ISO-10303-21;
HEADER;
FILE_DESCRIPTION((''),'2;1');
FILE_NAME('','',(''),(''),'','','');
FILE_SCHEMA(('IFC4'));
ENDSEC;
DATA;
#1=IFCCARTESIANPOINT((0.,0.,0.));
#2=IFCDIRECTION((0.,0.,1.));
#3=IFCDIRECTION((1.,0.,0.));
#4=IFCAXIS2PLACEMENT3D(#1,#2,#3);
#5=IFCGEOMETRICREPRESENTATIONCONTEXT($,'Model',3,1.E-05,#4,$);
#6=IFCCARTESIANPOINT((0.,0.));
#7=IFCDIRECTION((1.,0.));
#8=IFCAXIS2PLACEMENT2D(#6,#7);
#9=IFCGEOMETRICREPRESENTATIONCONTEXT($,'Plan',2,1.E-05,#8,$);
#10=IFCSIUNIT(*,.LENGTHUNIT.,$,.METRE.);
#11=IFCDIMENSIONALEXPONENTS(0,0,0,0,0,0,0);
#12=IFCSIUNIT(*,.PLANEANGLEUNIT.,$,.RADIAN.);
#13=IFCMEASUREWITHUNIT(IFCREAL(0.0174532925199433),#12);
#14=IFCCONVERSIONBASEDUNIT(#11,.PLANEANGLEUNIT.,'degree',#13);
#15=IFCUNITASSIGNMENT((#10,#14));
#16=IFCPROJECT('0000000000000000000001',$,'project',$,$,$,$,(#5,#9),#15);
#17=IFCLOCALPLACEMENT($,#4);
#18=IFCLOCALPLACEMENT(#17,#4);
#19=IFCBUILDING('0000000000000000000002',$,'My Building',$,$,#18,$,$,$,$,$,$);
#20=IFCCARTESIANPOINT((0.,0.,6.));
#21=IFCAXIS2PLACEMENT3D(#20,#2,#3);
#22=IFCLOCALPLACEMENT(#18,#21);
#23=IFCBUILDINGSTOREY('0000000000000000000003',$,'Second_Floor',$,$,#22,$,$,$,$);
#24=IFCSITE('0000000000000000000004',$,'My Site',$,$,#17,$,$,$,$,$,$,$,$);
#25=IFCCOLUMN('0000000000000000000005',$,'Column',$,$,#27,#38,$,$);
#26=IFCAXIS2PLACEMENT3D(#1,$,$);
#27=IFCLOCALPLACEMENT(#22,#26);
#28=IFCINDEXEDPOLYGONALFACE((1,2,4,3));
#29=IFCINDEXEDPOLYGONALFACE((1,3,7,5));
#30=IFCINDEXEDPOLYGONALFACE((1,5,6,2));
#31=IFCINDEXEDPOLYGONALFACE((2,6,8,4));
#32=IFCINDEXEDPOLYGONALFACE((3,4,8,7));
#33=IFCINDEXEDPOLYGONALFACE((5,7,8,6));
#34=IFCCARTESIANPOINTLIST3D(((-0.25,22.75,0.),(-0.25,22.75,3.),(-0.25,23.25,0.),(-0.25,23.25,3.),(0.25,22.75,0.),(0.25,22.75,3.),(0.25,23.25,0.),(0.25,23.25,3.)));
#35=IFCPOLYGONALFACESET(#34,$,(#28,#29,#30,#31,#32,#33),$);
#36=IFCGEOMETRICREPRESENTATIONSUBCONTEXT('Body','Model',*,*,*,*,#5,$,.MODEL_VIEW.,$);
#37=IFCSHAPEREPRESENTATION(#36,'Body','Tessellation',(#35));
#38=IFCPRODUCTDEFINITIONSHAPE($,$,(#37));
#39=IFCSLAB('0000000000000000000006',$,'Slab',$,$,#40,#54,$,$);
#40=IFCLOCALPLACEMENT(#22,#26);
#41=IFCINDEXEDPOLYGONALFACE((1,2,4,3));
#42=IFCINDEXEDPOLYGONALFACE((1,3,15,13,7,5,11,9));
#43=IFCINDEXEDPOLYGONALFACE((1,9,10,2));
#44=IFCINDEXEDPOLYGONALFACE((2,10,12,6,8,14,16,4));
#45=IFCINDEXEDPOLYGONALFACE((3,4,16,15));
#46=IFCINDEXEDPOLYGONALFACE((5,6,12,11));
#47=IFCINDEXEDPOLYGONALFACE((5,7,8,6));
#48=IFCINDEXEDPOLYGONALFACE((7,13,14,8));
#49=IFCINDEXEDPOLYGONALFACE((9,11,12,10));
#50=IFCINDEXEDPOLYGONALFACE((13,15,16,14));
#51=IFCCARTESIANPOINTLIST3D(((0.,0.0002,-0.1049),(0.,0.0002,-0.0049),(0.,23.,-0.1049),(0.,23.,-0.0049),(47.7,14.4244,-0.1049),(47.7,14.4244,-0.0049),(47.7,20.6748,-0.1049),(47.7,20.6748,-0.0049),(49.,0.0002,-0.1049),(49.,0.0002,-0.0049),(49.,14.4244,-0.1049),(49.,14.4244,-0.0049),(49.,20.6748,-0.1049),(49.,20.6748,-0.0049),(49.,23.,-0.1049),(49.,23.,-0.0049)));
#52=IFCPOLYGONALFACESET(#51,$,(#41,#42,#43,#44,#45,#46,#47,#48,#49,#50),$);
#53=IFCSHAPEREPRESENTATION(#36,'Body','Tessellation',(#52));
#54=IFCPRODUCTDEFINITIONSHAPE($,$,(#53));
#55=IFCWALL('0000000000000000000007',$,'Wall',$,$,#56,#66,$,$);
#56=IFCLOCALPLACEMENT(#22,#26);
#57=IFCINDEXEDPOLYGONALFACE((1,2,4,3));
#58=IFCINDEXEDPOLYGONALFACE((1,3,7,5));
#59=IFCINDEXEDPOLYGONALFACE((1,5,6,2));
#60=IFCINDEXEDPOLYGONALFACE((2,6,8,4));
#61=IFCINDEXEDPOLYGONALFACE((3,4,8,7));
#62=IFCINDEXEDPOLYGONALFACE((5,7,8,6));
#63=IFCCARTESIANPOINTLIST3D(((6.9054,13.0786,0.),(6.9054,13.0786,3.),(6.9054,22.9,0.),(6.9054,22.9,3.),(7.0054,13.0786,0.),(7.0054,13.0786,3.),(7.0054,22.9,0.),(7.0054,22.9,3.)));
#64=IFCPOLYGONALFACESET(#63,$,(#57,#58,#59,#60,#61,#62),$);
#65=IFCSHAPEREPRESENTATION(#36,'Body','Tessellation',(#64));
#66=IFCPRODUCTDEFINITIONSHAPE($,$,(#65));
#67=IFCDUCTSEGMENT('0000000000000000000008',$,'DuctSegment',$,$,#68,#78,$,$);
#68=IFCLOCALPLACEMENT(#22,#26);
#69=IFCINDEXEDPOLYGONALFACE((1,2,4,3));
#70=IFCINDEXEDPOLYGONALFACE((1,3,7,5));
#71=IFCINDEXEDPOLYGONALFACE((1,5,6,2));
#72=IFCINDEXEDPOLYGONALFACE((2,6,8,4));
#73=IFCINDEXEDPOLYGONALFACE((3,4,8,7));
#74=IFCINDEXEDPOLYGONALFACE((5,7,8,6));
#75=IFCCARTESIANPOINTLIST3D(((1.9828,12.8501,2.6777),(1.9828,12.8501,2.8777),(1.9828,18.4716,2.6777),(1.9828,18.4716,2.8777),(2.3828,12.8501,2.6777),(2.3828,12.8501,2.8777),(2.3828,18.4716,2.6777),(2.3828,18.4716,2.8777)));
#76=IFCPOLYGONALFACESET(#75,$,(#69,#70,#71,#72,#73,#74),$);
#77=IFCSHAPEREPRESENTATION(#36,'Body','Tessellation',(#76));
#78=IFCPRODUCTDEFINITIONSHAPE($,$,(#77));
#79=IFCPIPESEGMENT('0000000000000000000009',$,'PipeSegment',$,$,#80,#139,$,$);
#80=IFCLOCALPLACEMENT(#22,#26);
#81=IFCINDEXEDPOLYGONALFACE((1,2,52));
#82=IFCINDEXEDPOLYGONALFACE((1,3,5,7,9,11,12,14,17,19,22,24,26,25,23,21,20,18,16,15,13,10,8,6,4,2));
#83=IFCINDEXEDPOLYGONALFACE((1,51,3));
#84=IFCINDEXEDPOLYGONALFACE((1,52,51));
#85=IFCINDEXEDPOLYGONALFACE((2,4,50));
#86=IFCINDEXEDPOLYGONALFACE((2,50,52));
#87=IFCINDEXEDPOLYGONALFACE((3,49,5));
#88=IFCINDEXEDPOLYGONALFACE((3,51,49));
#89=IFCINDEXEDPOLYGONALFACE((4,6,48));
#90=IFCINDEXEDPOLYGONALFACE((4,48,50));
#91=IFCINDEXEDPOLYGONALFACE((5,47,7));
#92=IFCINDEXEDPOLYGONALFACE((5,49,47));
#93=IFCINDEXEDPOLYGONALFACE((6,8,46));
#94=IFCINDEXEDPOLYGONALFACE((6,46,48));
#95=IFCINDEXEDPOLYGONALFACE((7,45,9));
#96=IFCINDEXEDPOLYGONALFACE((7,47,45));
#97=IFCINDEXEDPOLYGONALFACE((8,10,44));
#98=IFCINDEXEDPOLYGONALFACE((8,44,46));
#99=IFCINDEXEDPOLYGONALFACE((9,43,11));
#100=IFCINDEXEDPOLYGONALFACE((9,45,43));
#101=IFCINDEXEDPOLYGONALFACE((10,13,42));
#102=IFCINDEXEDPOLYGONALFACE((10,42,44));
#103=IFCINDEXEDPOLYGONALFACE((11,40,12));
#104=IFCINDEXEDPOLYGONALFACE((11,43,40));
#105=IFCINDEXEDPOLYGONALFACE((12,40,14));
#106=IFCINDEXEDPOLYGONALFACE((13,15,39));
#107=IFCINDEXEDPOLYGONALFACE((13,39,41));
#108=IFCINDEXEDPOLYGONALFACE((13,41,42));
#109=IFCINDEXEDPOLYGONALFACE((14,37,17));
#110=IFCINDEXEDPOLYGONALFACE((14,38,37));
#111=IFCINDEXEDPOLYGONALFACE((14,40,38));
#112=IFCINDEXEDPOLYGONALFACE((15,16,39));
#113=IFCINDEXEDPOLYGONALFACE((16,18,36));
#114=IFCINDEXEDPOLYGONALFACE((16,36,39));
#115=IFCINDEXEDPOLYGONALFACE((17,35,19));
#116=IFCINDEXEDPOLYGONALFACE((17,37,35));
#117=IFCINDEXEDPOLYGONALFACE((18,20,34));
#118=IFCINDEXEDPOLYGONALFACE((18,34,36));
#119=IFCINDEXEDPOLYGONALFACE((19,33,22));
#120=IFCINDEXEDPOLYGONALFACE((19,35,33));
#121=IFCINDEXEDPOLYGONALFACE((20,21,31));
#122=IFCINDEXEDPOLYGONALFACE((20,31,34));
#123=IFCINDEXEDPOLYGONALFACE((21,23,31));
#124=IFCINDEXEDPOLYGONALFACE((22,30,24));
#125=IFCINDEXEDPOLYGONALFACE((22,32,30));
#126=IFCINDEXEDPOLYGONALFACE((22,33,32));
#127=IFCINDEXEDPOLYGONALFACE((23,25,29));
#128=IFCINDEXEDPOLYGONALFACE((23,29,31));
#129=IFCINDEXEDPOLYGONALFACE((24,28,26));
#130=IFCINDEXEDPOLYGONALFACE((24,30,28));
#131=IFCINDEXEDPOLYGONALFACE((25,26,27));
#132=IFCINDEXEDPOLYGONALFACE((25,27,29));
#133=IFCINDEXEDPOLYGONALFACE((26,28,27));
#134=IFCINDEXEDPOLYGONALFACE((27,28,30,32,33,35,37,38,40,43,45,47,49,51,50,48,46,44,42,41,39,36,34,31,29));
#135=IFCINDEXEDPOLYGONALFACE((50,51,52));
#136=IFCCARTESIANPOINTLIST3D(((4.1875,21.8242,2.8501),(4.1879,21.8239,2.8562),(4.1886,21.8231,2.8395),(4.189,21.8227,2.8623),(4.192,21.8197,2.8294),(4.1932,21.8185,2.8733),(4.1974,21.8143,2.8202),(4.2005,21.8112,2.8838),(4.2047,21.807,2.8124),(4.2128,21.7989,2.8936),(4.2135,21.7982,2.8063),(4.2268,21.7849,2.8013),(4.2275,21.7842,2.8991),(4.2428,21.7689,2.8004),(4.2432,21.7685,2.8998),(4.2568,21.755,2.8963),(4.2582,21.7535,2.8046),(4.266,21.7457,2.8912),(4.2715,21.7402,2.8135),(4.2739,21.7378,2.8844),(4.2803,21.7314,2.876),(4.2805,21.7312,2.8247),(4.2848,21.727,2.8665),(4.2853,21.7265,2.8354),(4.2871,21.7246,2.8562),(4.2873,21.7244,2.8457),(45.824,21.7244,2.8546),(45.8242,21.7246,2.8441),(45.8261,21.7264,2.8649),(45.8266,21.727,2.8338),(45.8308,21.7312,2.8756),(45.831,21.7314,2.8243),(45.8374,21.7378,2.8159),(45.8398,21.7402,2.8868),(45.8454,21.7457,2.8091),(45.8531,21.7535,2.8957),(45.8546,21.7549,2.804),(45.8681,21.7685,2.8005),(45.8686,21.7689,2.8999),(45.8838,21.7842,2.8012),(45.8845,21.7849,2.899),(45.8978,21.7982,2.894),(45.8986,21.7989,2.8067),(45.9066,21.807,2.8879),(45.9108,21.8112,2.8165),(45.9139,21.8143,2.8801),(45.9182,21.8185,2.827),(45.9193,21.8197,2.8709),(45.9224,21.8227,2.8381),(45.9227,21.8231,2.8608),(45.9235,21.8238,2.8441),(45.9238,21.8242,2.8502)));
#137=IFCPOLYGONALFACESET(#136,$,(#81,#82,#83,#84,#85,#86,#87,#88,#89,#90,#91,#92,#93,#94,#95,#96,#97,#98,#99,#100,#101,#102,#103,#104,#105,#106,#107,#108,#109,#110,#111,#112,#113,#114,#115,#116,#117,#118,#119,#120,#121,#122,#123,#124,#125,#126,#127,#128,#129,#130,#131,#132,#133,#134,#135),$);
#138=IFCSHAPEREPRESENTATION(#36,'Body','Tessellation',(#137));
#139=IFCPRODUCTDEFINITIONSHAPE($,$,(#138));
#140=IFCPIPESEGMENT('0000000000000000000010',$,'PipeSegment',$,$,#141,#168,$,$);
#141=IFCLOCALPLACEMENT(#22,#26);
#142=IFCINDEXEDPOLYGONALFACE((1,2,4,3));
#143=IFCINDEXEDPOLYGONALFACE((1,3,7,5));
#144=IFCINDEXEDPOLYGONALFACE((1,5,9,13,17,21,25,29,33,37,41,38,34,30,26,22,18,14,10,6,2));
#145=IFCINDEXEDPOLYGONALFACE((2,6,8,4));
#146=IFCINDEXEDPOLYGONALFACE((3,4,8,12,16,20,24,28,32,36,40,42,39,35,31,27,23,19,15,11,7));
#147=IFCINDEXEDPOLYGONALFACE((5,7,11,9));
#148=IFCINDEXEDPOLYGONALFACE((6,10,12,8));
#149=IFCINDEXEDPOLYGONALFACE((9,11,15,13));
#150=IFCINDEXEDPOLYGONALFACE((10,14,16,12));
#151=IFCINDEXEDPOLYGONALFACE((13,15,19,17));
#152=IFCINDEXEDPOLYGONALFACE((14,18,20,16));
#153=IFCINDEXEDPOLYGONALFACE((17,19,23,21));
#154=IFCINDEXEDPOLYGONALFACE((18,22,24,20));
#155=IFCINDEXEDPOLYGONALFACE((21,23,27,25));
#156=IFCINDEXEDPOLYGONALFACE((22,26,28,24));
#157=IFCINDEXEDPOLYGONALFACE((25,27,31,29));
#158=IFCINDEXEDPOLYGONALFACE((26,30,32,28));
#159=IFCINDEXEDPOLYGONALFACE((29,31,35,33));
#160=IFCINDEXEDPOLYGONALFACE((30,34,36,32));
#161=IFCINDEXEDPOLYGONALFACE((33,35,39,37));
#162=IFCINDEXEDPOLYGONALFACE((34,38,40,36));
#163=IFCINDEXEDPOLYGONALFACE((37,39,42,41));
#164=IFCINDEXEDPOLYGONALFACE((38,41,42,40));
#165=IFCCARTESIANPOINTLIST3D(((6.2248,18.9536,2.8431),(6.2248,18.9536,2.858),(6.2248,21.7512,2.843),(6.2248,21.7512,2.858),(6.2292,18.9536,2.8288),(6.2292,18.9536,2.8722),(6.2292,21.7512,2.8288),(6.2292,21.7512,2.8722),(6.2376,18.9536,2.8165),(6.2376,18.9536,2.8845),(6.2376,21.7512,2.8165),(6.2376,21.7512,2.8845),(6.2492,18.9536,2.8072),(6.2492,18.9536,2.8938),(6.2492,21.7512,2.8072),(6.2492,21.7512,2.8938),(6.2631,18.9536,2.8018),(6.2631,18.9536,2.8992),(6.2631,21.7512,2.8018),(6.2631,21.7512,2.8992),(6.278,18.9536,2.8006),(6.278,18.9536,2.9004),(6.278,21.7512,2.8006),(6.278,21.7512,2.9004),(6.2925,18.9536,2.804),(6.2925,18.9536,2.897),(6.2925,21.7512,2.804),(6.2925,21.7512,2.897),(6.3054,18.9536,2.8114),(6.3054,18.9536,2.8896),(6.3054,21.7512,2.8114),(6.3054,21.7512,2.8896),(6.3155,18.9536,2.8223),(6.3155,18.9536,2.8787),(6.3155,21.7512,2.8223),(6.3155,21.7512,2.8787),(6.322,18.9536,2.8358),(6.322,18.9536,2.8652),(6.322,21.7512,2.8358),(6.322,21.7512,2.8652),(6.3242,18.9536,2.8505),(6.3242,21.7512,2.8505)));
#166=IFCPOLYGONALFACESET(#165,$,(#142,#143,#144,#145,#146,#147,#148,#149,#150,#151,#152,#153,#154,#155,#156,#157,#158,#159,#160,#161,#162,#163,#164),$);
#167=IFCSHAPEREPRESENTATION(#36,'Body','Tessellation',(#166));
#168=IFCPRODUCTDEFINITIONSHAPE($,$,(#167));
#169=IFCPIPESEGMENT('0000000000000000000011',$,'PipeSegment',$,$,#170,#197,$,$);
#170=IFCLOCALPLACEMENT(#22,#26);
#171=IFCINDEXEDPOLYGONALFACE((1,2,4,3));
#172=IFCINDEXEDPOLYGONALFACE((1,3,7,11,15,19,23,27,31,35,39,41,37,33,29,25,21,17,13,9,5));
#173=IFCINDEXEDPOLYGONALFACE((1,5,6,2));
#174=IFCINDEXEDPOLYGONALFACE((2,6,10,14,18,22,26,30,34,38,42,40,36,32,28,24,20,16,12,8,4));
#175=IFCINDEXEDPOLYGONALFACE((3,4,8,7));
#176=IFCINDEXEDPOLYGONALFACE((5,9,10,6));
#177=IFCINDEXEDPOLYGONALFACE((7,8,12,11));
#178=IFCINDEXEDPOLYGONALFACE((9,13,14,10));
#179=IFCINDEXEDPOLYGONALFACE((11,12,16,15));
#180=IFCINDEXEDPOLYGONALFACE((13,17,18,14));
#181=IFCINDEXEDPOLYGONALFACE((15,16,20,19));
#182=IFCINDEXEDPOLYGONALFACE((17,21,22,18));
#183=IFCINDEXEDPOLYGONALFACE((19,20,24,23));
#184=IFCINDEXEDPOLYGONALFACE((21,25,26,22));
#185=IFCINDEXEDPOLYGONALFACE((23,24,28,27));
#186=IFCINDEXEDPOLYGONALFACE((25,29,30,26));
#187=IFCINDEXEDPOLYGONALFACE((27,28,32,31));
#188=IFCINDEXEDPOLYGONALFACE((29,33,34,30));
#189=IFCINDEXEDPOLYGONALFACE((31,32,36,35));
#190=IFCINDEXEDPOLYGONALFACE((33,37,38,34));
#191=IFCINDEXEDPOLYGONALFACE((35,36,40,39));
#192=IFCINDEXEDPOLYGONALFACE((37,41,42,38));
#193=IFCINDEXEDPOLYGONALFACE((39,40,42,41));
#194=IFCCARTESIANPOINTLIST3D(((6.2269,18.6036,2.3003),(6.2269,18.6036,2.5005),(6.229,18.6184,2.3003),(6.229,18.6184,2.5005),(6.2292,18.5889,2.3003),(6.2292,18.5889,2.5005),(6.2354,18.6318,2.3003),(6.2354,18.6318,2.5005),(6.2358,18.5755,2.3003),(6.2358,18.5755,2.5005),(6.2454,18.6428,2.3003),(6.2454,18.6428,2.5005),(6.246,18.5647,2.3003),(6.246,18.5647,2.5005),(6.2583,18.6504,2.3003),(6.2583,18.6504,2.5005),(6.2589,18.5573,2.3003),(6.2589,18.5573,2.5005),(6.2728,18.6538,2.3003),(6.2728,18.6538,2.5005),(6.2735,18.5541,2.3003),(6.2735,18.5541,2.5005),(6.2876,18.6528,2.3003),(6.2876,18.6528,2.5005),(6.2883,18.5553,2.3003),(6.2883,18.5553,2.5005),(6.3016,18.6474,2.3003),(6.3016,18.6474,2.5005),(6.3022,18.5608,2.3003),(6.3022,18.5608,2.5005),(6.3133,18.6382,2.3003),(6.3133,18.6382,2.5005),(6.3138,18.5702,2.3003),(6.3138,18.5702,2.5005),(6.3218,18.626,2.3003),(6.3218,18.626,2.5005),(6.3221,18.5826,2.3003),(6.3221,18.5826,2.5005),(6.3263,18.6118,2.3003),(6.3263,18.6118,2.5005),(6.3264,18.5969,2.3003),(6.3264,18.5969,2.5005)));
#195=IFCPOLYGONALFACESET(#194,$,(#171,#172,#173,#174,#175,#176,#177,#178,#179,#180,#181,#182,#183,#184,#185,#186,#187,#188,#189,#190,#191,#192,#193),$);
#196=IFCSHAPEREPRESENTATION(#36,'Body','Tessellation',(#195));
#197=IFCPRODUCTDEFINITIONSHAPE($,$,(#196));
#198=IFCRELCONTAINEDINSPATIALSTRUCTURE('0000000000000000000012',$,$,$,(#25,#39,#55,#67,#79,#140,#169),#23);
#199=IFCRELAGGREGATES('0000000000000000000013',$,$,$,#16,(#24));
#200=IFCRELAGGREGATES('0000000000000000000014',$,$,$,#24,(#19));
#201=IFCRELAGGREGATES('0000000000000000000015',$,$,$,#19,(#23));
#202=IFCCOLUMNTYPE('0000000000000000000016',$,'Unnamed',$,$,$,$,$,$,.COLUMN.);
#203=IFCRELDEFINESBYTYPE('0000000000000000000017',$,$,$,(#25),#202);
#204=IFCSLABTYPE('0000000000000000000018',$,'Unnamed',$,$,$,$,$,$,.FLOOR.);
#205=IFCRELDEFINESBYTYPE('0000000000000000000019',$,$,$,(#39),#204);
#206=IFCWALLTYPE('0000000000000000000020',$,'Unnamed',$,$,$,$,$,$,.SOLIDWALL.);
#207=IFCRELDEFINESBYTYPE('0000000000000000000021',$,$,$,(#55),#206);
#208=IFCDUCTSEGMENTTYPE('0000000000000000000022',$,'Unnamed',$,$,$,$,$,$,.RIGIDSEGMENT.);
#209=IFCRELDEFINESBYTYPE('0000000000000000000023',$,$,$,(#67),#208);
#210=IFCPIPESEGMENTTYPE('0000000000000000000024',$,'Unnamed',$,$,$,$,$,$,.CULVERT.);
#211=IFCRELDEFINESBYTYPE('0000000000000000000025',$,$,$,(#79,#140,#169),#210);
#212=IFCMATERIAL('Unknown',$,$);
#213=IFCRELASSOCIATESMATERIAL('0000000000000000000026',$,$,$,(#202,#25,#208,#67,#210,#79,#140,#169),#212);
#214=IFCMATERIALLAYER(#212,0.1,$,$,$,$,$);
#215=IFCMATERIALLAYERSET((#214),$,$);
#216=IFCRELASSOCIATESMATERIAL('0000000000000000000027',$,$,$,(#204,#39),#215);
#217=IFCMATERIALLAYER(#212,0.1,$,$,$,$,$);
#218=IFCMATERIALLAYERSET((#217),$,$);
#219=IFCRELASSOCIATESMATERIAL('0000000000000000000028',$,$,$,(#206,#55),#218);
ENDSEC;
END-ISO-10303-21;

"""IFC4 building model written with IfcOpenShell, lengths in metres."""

from ifc_helpers import new_model, entity, si_unit, converted_unit, frame, origin_with_axes, origin_2d_with_axis, place, context, subcontext, project, spatial, line, indexed_curve, rectangle, circle, outline, extrude, clip, halfspace, material, layer, layer_set, layer_usage, material_profile, profile_set, profile_usage, type_object, element, save


model = new_model("IFC4")

# Units and contexts
model_context = context("Model", 3, precision=1e-05, world=origin_with_axes())
plan_context = context("Plan", 2, precision=1e-05, world=origin_2d_with_axis())
body_context_1 = subcontext(model_context, "Body", "Model", "MODEL_VIEW")
ifc_project = project(units=[si_unit("LENGTHUNIT", "METRE"), converted_unit("PLANEANGLEUNIT", "degree", entity("IfcReal", 0.0174532925199433), si_unit("PLANEANGLEUNIT", "RADIAN"), dimensions=[0, 0, 0, 0, 0, 0, 0])], contexts=[model_context, plan_context])

# Site, building, storey
site_placement = place(None, origin_with_axes())
site = spatial("IfcSite", under=ifc_project, at=site_placement, Name="My Site")
building_placement = place(site_placement, origin_with_axes())
building = spatial("IfcBuilding", under=site, at=building_placement, Name="My Building")
storey_placement = place(building_placement, frame((0.0, 0.0, 6.0), z_axis=(0.0, 0.0, 1.0), x_axis=(1.0, 0.0, 0.0)))
storey = spatial("IfcBuildingStorey", under=building, at=storey_placement, Name="Second_Floor")

# Column
ifc_material = material(Name="Unknown")
ifc_material_profile_1 = material_profile(ifc_material, rectangle(XDim=0.5, YDim=0.5))
ifc_profile_set_1 = profile_set([ifc_material_profile_1])
ifc_profile_usage_1 = profile_usage(ifc_profile_set_1, cardinal=5)
column_type = type_object("IfcColumnType", Name="Unnamed", PredefinedType="COLUMN", material=ifc_profile_set_1)
column_placement = place(storey_placement, frame((0.0, 23.0, 0.0), z_axis=(0.0, 0.0, 1.0), x_axis=(1.0, 0.0, 0.0)))
element("IfcColumn", 1, at=column_placement, inside=storey, type_object=column_type, material=ifc_profile_usage_1, Name="Column", context=body_context_1, shape_type="SweptSolid", body=[
    extrude(rectangle(XDim=0.5, YDim=0.5), origin_with_axes(), (0.0, 0.0, 1.0), 3.0),
])

# Slab
ifc_layer_1 = layer(ifc_material, 0.1)
ifc_layer_set_1 = layer_set([ifc_layer_1])
ifc_layer_usage_1 = layer_usage(ifc_layer_set_1, "AXIS3", "POSITIVE", -0.1)
slab_type = type_object("IfcSlabType", Name="Unnamed", PredefinedType="FLOOR", material=ifc_layer_set_1)
slab_placement = place(storey_placement, frame((0.0, 23.0, -0.0049), z_axis=(0.0, 0.0, 1.0), x_axis=(1.0, 0.0, 0.0)))
element("IfcSlab", 2, at=slab_placement, inside=storey, type_object=slab_type, material=ifc_layer_usage_1, Name="Slab", context=body_context_1, shape_type="SweptSolid", body=[
    extrude(outline(indexed_curve([(0.0, 0.0), (49.0, 0.0), (49.0, -2.3252), (47.7, -2.3252), (47.7, -8.5756), (49.0, -8.5756), (49.0, -22.9998), (0.0, -22.9998), (0.0, 0.0)])), frame((0.0, 0.0, -0.1), z_axis=(0.0, 0.0, 1.0), x_axis=(1.0, 0.0, 0.0)), (0.0, 0.0, 1.0), 0.1),
])

# Shared definitions
ifc_layer_2 = layer(ifc_material, 0.1)
ifc_layer_set_2 = layer_set([ifc_layer_2])
wall_type = type_object("IfcWallType", Name="Unnamed", PredefinedType="SOLIDWALL", material=ifc_layer_set_2)

# Wall
ifc_layer_usage_2 = layer_usage(ifc_layer_set_2, "AXIS2", "POSITIVE", 0.0)
wall_1_placement = place(storey_placement, frame((6.9054, 22.9, 0.0), z_axis=(0.0, 0.0, 1.0), x_axis=(0.0, -1.0, 0.0)))
element("IfcWall", 3, at=wall_1_placement, inside=storey, type_object=wall_type, material=ifc_layer_usage_2, Name="Wall", context=body_context_1, shape_type="SweptSolid", body=[
    extrude(outline(indexed_curve([(0.0, 0.0), (0.0, 0.1), (9.8214, 0.1), (9.8214, 0.0)], segments=[line(1, 2, 3, 4, 1)])), origin_with_axes(), (0.0, 0.0, 1.0), 3.0),
])

# Duct segment
ifc_material_profile_2 = material_profile(ifc_material, rectangle(XDim=0.4, YDim=0.2))
ifc_profile_set_2 = profile_set([ifc_material_profile_2])
ifc_profile_usage_2 = profile_usage(ifc_profile_set_2, cardinal=5)
duct_segment_type = type_object("IfcDuctSegmentType", Name="Unnamed", PredefinedType="RIGIDSEGMENT", material=ifc_profile_set_2)
duct_segment_placement = place(storey_placement, frame((2.1828, 18.4716, 2.7777), z_axis=(0.0, -1.0, 0.0), x_axis=(1.0, 0.0, 0.0)))
element("IfcDuctSegment", 4, at=duct_segment_placement, inside=storey, type_object=duct_segment_type, material=ifc_profile_usage_2, Name="DuctSegment", context=body_context_1, shape_type="SweptSolid", body=[
    extrude(rectangle(XDim=0.4, YDim=0.2), origin_with_axes(), (0.0, 0.0, 1.0), 5.6215),
])

# Pipe segments
ifc_material_profile_3 = material_profile(ifc_material, circle(Radius=0.05))
ifc_profile_set_3 = profile_set([ifc_material_profile_3])
ifc_profile_usage_3 = profile_usage(ifc_profile_set_3, cardinal=5)
pipe_segment_type = type_object("IfcPipeSegmentType", Name="Unnamed", PredefinedType="CULVERT", material=ifc_profile_set_3)
pipe_segment_1_placement = place(storey_placement, frame((4.1875, 21.7742, 2.8501), z_axis=(1.0, 0.0, 0.0), x_axis=(0.0, 1.0, 0.0)))
element("IfcPipeSegment", 5, at=pipe_segment_1_placement, inside=storey, type_object=pipe_segment_type, material=ifc_profile_usage_3, Name="PipeSegment", context=body_context_1, shape_type="Clipping", body=[
    clip(clip(extrude(circle(Radius=0.05), origin_with_axes(), (0.0, 0.0, 1.0), 41.7363), halfspace(frame((0.05, -3.0, 41.7364), z_axis=(-0.707107, 0.0, 0.707107), x_axis=(0.0, 1.0, 0.0)), False)), halfspace(frame((0.05, -3.0, 0.0), z_axis=(-0.707114, 0.0, -0.7071), x_axis=(0.0, 1.0, 0.0)), False)),
])
ifc_profile_usage_4 = profile_usage(ifc_profile_set_3, cardinal=5)
pipe_segment_2_placement = place(storey_placement, frame((6.2742, 21.7512, 2.8505), z_axis=(0.0, -1.0, 0.0), x_axis=(1.0, 0.0, 0.0)))
element("IfcPipeSegment", 6, at=pipe_segment_2_placement, inside=storey, type_object=pipe_segment_type, material=ifc_profile_usage_4, Name="PipeSegment", context=body_context_1, shape_type="SweptSolid", body=[
    extrude(circle(Radius=0.05), origin_with_axes(), (0.0, 0.0, 1.0), 2.7976),
])
ifc_profile_usage_5 = profile_usage(ifc_profile_set_3, cardinal=5)
pipe_segment_3_placement = place(storey_placement, frame((6.2769, 18.604, 2.5005), z_axis=(-0.000001, 0.0, -1.0), x_axis=(-0.999975, -0.007084, 0.000001)))
element("IfcPipeSegment", 7, at=pipe_segment_3_placement, inside=storey, type_object=pipe_segment_type, material=ifc_profile_usage_5, Name="PipeSegment", context=body_context_1, shape_type="SweptSolid", body=[
    extrude(circle(Radius=0.05), origin_with_axes(), (0.0, 0.0, 1.0), 0.2002),
])

save(model, "model.ifc")
